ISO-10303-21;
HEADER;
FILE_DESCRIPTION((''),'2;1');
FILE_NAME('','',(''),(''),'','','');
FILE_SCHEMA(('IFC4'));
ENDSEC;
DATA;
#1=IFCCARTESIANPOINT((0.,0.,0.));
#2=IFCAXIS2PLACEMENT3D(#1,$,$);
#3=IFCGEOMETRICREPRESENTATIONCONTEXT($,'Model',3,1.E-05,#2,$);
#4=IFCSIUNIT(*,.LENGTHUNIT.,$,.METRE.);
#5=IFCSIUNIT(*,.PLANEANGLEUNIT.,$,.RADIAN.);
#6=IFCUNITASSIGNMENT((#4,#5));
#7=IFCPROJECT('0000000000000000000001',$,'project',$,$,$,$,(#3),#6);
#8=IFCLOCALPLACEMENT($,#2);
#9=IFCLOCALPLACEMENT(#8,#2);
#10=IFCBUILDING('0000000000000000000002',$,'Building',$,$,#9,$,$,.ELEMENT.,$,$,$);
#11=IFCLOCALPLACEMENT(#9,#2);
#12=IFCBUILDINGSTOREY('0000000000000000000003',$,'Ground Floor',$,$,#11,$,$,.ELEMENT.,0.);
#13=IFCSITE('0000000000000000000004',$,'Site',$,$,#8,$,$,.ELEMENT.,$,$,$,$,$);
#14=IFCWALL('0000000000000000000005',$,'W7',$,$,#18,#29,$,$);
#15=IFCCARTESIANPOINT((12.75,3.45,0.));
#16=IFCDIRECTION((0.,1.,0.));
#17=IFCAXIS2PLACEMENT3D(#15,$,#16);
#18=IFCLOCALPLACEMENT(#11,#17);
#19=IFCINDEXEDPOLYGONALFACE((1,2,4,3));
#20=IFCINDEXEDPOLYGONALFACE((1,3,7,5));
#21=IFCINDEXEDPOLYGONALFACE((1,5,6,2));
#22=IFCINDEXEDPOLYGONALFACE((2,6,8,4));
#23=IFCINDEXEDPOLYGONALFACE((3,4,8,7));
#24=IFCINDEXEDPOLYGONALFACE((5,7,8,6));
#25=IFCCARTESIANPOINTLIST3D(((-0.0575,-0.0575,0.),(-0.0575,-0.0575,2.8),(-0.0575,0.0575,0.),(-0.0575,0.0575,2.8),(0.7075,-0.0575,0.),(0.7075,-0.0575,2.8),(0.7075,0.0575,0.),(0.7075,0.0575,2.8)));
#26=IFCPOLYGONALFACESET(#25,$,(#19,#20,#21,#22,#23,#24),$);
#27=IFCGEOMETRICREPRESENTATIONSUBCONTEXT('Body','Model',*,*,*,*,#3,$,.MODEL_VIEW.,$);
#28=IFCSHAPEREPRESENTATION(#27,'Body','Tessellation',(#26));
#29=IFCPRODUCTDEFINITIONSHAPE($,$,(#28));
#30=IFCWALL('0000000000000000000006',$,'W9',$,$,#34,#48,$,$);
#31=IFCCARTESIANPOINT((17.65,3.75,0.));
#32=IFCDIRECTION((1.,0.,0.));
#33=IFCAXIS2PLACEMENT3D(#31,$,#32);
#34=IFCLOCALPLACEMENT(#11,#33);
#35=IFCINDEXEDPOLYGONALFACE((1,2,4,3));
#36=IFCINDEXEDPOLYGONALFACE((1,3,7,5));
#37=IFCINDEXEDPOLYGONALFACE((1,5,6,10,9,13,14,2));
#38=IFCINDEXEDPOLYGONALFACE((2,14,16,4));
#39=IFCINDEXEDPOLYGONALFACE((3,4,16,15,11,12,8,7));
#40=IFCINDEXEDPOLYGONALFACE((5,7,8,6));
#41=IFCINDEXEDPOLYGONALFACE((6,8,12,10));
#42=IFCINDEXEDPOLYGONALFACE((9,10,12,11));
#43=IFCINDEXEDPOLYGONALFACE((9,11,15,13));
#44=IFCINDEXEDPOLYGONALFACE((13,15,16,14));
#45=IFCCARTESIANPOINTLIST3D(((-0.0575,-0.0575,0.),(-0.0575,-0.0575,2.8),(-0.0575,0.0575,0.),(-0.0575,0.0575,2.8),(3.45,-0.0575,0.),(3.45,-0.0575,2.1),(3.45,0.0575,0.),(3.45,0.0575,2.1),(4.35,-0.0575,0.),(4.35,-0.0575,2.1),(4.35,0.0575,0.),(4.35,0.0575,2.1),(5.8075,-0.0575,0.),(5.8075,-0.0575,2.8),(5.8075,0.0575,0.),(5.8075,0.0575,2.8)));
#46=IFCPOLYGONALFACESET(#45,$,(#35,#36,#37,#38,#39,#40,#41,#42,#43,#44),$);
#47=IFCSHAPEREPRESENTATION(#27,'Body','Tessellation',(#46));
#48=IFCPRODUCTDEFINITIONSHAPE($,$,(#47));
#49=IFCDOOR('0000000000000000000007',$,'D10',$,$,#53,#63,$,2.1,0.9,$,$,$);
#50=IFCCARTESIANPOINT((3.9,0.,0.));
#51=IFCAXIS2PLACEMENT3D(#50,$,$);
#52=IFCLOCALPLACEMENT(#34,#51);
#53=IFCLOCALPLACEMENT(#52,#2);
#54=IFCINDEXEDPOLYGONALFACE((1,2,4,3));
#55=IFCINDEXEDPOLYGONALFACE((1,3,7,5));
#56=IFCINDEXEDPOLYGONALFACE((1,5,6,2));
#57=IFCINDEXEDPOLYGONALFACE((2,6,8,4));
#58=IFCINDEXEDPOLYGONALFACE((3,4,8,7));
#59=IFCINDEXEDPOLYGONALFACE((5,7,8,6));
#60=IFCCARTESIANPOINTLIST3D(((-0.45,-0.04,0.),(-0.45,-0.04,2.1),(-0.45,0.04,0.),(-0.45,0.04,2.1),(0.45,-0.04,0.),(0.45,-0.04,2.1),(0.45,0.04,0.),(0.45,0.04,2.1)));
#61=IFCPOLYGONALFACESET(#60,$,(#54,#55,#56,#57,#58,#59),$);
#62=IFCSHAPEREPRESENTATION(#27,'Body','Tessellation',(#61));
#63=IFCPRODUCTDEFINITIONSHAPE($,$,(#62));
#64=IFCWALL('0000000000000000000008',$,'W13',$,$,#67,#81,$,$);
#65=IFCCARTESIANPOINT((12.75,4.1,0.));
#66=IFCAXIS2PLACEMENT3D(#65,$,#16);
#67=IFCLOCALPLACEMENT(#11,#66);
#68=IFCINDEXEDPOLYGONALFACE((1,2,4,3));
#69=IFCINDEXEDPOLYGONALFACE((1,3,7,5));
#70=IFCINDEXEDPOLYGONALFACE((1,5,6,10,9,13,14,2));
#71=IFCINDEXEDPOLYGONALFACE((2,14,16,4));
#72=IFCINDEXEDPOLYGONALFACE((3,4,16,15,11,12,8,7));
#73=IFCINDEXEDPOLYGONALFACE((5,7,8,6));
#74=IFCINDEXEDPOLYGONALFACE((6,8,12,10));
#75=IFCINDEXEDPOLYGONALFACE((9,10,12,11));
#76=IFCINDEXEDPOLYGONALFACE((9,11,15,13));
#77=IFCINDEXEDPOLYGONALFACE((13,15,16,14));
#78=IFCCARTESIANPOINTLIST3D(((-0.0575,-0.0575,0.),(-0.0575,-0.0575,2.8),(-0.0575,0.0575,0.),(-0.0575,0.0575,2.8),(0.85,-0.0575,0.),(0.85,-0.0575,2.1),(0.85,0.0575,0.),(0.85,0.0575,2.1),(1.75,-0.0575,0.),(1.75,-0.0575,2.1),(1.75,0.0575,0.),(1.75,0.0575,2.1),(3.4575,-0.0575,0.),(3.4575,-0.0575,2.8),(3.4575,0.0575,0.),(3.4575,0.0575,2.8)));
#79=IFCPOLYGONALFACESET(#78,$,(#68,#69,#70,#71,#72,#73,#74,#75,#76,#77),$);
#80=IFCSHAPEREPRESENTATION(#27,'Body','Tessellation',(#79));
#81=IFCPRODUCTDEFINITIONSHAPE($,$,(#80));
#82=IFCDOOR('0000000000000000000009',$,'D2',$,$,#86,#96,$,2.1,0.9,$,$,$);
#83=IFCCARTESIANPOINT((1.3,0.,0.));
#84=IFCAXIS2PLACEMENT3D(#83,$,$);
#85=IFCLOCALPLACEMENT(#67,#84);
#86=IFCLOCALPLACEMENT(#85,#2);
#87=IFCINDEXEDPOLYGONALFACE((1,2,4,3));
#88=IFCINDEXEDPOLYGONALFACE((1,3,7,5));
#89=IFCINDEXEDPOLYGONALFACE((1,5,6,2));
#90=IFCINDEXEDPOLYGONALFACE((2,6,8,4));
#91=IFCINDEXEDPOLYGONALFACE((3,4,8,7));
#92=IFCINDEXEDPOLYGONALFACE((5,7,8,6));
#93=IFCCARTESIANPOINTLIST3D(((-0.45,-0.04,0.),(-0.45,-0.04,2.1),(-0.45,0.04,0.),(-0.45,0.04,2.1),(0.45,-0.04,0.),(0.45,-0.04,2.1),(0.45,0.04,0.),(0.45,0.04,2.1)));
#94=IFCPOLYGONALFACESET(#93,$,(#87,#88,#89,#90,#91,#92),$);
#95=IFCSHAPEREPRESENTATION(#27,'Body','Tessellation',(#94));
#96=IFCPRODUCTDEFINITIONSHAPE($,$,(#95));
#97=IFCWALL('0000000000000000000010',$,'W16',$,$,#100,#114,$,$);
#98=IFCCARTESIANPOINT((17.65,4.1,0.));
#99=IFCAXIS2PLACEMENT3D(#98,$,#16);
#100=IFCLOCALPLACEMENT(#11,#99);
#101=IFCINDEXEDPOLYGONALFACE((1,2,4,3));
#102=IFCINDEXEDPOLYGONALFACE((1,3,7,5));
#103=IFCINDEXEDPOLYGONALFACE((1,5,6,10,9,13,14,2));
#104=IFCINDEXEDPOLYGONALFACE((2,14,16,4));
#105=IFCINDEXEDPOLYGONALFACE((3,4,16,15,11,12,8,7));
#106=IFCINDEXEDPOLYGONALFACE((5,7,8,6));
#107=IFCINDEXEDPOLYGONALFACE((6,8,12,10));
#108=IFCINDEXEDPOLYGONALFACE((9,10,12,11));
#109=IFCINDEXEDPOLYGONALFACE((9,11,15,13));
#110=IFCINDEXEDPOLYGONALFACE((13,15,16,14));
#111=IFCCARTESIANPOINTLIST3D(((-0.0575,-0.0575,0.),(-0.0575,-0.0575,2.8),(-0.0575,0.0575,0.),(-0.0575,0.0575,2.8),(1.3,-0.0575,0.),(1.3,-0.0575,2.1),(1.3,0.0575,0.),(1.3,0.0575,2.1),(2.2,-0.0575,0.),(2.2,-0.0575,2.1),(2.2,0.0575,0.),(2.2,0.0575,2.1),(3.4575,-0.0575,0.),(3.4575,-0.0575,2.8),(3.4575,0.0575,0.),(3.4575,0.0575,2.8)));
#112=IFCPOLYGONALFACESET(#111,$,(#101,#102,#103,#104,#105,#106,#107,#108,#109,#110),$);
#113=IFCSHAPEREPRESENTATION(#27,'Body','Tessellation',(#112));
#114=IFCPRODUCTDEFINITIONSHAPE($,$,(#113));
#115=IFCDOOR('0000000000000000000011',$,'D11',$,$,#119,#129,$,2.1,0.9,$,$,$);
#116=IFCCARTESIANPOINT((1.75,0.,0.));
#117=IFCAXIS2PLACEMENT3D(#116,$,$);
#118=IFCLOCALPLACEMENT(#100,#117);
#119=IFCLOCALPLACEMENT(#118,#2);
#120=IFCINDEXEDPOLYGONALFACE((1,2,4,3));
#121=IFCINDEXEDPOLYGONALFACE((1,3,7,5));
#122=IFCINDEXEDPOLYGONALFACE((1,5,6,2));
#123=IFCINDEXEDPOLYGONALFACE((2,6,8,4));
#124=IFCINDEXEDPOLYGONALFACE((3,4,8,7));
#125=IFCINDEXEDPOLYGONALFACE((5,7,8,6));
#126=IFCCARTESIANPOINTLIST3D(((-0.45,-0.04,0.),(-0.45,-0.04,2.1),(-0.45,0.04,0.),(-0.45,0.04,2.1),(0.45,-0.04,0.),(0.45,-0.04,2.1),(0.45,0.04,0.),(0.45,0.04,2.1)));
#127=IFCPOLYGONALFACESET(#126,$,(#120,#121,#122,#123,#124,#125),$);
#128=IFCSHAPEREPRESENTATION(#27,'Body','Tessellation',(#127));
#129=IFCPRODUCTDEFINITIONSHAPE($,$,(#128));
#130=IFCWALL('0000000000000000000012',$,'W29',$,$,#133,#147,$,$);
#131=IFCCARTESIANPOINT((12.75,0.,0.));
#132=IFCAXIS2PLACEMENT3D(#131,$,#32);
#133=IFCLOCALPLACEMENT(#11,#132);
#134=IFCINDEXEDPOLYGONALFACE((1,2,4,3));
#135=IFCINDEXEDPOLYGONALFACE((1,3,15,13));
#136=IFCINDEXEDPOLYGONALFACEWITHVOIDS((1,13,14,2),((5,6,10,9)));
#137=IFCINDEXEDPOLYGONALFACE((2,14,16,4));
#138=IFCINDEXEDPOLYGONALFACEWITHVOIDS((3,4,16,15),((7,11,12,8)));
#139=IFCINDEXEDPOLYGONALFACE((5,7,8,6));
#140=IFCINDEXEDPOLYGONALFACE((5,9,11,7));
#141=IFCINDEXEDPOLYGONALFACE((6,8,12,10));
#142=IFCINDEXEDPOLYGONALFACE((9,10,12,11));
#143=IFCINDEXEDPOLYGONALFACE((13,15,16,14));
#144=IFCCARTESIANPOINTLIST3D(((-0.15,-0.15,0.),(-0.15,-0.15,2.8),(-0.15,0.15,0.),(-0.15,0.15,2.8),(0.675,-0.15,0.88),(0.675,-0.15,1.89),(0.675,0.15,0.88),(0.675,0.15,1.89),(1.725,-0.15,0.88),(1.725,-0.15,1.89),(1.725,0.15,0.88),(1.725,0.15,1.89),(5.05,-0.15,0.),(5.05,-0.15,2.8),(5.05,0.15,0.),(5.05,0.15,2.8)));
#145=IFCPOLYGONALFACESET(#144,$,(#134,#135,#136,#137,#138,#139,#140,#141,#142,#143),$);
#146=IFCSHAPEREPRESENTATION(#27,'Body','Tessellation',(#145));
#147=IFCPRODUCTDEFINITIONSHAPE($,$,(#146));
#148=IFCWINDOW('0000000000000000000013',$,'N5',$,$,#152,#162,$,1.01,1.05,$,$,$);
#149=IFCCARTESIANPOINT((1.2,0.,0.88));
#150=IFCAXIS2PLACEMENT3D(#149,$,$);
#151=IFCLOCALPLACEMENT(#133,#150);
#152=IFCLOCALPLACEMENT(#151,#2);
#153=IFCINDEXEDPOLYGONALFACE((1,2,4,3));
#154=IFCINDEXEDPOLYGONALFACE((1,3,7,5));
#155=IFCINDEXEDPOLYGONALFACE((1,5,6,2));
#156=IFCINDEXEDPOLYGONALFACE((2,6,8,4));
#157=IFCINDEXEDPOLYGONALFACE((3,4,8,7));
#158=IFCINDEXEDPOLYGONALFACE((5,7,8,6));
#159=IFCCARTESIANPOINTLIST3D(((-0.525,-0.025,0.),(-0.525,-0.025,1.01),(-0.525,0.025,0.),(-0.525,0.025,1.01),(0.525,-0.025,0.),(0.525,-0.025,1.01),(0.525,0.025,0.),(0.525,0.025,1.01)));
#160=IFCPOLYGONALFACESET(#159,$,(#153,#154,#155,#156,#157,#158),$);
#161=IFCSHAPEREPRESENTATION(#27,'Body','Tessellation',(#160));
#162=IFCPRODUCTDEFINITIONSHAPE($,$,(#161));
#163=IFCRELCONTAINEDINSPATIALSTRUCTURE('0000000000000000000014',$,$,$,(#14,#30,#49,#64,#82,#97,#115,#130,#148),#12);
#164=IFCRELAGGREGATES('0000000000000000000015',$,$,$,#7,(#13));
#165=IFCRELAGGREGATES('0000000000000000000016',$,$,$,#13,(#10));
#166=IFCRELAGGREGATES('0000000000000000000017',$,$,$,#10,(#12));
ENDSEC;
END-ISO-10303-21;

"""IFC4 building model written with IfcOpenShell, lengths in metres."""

from ifc_helpers import new_model, si_unit, frame, frame_2d, origin, origin_2d, place, context, subcontext, project, spatial, rectangle, extrude, element, fill, save


model = new_model("IFC4")

# Units and contexts
model_context = context("Model", 3, precision=1e-05, world=origin())
body_context = subcontext(model_context, "Body", "Model", "MODEL_VIEW")
ifc_project = project(units=[si_unit("LENGTHUNIT", "METRE"), si_unit("PLANEANGLEUNIT", "RADIAN")], contexts=[model_context])

# Site, building, storey
site_placement = place(None, origin())
site = spatial("IfcSite", under=ifc_project, at=site_placement, Name="Site", CompositionType="ELEMENT")
building_placement = place(site_placement, origin())
building = spatial("IfcBuilding", under=site, at=building_placement, Name="Building", CompositionType="ELEMENT")
storey_placement = place(building_placement, origin())
storey = spatial("IfcBuildingStorey", under=building, at=storey_placement, Name="Ground Floor", CompositionType="ELEMENT", Elevation=0.0)

# Wall
wall_1_placement = place(storey_placement, frame((12.75, 3.45, 0.0), x_axis=(0.0, 1.0, 0.0)))
element("IfcWall", 1, at=wall_1_placement, inside=storey, Name="W7", context=body_context, shape_type="SweptSolid", body=[
    extrude(rectangle(XDim=0.765, YDim=0.115, at=frame_2d((0.325, 0.0))), origin(), (0.0, 0.0, 1.0), 2.8),
])

# Walls, openings, doors
wall_2_placement = place(storey_placement, frame((17.65, 3.75, 0.0), x_axis=(1.0, 0.0, 0.0)))
wall_2 = element("IfcWall", 2, at=wall_2_placement, inside=storey, Name="W9", context=body_context, shape_type="SweptSolid", body=[
    extrude(rectangle(XDim=5.865, YDim=0.115, at=frame_2d((2.875, 0.0))), origin(), (0.0, 0.0, 1.0), 2.8),
])
opening_1_placement = place(wall_2_placement, frame((3.9, 0.0, 0.0)))
opening_1 = element("IfcOpeningElement", 3, at=opening_1_placement, cuts=wall_2, context=body_context, shape_type="SweptSolid", body=[
    extrude(rectangle(XDim=0.9, YDim=0.215, at=origin_2d()), origin(), (0.0, 0.0, 1.0), 2.1),
])
door_1_placement = place(opening_1_placement, origin())
door_1 = element("IfcDoor", 4, at=door_1_placement, inside=storey, Name="D10", OverallHeight=2.1, OverallWidth=0.9, context=body_context, shape_type="SweptSolid", body=[
    extrude(rectangle(XDim=0.9, YDim=0.08, at=origin_2d()), origin(), (0.0, 0.0, 1.0), 2.1),
])
fill(opening_1, door_1)
wall_3_placement = place(storey_placement, frame((12.75, 4.1, 0.0), x_axis=(0.0, 1.0, 0.0)))
wall_3 = element("IfcWall", 5, at=wall_3_placement, inside=storey, Name="W13", context=body_context, shape_type="SweptSolid", body=[
    extrude(rectangle(XDim=3.515, YDim=0.115, at=frame_2d((1.7, 0.0))), origin(), (0.0, 0.0, 1.0), 2.8),
])
opening_2_placement = place(wall_3_placement, frame((1.3, 0.0, 0.0)))
opening_2 = element("IfcOpeningElement", 6, at=opening_2_placement, cuts=wall_3, context=body_context, shape_type="SweptSolid", body=[
    extrude(rectangle(XDim=0.9, YDim=0.215, at=origin_2d()), origin(), (0.0, 0.0, 1.0), 2.1),
])
door_2_placement = place(opening_2_placement, origin())
door_2 = element("IfcDoor", 7, at=door_2_placement, inside=storey, Name="D2", OverallHeight=2.1, OverallWidth=0.9, context=body_context, shape_type="SweptSolid", body=[
    extrude(rectangle(XDim=0.9, YDim=0.08, at=origin_2d()), origin(), (0.0, 0.0, 1.0), 2.1),
])
fill(opening_2, door_2)
wall_4_placement = place(storey_placement, frame((17.65, 4.1, 0.0), x_axis=(0.0, 1.0, 0.0)))
wall_4 = element("IfcWall", 8, at=wall_4_placement, inside=storey, Name="W16", context=body_context, shape_type="SweptSolid", body=[
    extrude(rectangle(XDim=3.515, YDim=0.115, at=frame_2d((1.7, 0.0))), origin(), (0.0, 0.0, 1.0), 2.8),
])
opening_3_placement = place(wall_4_placement, frame((1.75, 0.0, 0.0)))
opening_3 = element("IfcOpeningElement", 9, at=opening_3_placement, cuts=wall_4, context=body_context, shape_type="SweptSolid", body=[
    extrude(rectangle(XDim=0.9, YDim=0.215, at=origin_2d()), origin(), (0.0, 0.0, 1.0), 2.1),
])
door_3_placement = place(opening_3_placement, origin())
door_3 = element("IfcDoor", 10, at=door_3_placement, inside=storey, Name="D11", OverallHeight=2.1, OverallWidth=0.9, context=body_context, shape_type="SweptSolid", body=[
    extrude(rectangle(XDim=0.9, YDim=0.08, at=origin_2d()), origin(), (0.0, 0.0, 1.0), 2.1),
])
fill(opening_3, door_3)

# Wall, opening, window
wall_5_placement = place(storey_placement, frame((12.75, 0.0, 0.0), x_axis=(1.0, 0.0, 0.0)))
wall_5 = element("IfcWall", 11, at=wall_5_placement, inside=storey, Name="W29", context=body_context, shape_type="SweptSolid", body=[
    extrude(rectangle(XDim=5.2, YDim=0.3, at=frame_2d((2.45, 0.0))), origin(), (0.0, 0.0, 1.0), 2.8),
])
opening_4_placement = place(wall_5_placement, frame((1.2, 0.0, 0.88)))
opening_4 = element("IfcOpeningElement", 12, at=opening_4_placement, cuts=wall_5, context=body_context, shape_type="SweptSolid", body=[
    extrude(rectangle(XDim=1.05, YDim=0.4, at=origin_2d()), origin(), (0.0, 0.0, 1.0), 1.01),
])
window_1_placement = place(opening_4_placement, origin())
window_1 = element("IfcWindow", 13, at=window_1_placement, inside=storey, Name="N5", OverallHeight=1.01, OverallWidth=1.05, context=body_context, shape_type="SweptSolid", body=[
    extrude(rectangle(XDim=1.05, YDim=0.05, at=origin_2d()), origin(), (0.0, 0.0, 1.0), 1.01),
])
fill(opening_4, window_1)

save(model, "model.ifc")
